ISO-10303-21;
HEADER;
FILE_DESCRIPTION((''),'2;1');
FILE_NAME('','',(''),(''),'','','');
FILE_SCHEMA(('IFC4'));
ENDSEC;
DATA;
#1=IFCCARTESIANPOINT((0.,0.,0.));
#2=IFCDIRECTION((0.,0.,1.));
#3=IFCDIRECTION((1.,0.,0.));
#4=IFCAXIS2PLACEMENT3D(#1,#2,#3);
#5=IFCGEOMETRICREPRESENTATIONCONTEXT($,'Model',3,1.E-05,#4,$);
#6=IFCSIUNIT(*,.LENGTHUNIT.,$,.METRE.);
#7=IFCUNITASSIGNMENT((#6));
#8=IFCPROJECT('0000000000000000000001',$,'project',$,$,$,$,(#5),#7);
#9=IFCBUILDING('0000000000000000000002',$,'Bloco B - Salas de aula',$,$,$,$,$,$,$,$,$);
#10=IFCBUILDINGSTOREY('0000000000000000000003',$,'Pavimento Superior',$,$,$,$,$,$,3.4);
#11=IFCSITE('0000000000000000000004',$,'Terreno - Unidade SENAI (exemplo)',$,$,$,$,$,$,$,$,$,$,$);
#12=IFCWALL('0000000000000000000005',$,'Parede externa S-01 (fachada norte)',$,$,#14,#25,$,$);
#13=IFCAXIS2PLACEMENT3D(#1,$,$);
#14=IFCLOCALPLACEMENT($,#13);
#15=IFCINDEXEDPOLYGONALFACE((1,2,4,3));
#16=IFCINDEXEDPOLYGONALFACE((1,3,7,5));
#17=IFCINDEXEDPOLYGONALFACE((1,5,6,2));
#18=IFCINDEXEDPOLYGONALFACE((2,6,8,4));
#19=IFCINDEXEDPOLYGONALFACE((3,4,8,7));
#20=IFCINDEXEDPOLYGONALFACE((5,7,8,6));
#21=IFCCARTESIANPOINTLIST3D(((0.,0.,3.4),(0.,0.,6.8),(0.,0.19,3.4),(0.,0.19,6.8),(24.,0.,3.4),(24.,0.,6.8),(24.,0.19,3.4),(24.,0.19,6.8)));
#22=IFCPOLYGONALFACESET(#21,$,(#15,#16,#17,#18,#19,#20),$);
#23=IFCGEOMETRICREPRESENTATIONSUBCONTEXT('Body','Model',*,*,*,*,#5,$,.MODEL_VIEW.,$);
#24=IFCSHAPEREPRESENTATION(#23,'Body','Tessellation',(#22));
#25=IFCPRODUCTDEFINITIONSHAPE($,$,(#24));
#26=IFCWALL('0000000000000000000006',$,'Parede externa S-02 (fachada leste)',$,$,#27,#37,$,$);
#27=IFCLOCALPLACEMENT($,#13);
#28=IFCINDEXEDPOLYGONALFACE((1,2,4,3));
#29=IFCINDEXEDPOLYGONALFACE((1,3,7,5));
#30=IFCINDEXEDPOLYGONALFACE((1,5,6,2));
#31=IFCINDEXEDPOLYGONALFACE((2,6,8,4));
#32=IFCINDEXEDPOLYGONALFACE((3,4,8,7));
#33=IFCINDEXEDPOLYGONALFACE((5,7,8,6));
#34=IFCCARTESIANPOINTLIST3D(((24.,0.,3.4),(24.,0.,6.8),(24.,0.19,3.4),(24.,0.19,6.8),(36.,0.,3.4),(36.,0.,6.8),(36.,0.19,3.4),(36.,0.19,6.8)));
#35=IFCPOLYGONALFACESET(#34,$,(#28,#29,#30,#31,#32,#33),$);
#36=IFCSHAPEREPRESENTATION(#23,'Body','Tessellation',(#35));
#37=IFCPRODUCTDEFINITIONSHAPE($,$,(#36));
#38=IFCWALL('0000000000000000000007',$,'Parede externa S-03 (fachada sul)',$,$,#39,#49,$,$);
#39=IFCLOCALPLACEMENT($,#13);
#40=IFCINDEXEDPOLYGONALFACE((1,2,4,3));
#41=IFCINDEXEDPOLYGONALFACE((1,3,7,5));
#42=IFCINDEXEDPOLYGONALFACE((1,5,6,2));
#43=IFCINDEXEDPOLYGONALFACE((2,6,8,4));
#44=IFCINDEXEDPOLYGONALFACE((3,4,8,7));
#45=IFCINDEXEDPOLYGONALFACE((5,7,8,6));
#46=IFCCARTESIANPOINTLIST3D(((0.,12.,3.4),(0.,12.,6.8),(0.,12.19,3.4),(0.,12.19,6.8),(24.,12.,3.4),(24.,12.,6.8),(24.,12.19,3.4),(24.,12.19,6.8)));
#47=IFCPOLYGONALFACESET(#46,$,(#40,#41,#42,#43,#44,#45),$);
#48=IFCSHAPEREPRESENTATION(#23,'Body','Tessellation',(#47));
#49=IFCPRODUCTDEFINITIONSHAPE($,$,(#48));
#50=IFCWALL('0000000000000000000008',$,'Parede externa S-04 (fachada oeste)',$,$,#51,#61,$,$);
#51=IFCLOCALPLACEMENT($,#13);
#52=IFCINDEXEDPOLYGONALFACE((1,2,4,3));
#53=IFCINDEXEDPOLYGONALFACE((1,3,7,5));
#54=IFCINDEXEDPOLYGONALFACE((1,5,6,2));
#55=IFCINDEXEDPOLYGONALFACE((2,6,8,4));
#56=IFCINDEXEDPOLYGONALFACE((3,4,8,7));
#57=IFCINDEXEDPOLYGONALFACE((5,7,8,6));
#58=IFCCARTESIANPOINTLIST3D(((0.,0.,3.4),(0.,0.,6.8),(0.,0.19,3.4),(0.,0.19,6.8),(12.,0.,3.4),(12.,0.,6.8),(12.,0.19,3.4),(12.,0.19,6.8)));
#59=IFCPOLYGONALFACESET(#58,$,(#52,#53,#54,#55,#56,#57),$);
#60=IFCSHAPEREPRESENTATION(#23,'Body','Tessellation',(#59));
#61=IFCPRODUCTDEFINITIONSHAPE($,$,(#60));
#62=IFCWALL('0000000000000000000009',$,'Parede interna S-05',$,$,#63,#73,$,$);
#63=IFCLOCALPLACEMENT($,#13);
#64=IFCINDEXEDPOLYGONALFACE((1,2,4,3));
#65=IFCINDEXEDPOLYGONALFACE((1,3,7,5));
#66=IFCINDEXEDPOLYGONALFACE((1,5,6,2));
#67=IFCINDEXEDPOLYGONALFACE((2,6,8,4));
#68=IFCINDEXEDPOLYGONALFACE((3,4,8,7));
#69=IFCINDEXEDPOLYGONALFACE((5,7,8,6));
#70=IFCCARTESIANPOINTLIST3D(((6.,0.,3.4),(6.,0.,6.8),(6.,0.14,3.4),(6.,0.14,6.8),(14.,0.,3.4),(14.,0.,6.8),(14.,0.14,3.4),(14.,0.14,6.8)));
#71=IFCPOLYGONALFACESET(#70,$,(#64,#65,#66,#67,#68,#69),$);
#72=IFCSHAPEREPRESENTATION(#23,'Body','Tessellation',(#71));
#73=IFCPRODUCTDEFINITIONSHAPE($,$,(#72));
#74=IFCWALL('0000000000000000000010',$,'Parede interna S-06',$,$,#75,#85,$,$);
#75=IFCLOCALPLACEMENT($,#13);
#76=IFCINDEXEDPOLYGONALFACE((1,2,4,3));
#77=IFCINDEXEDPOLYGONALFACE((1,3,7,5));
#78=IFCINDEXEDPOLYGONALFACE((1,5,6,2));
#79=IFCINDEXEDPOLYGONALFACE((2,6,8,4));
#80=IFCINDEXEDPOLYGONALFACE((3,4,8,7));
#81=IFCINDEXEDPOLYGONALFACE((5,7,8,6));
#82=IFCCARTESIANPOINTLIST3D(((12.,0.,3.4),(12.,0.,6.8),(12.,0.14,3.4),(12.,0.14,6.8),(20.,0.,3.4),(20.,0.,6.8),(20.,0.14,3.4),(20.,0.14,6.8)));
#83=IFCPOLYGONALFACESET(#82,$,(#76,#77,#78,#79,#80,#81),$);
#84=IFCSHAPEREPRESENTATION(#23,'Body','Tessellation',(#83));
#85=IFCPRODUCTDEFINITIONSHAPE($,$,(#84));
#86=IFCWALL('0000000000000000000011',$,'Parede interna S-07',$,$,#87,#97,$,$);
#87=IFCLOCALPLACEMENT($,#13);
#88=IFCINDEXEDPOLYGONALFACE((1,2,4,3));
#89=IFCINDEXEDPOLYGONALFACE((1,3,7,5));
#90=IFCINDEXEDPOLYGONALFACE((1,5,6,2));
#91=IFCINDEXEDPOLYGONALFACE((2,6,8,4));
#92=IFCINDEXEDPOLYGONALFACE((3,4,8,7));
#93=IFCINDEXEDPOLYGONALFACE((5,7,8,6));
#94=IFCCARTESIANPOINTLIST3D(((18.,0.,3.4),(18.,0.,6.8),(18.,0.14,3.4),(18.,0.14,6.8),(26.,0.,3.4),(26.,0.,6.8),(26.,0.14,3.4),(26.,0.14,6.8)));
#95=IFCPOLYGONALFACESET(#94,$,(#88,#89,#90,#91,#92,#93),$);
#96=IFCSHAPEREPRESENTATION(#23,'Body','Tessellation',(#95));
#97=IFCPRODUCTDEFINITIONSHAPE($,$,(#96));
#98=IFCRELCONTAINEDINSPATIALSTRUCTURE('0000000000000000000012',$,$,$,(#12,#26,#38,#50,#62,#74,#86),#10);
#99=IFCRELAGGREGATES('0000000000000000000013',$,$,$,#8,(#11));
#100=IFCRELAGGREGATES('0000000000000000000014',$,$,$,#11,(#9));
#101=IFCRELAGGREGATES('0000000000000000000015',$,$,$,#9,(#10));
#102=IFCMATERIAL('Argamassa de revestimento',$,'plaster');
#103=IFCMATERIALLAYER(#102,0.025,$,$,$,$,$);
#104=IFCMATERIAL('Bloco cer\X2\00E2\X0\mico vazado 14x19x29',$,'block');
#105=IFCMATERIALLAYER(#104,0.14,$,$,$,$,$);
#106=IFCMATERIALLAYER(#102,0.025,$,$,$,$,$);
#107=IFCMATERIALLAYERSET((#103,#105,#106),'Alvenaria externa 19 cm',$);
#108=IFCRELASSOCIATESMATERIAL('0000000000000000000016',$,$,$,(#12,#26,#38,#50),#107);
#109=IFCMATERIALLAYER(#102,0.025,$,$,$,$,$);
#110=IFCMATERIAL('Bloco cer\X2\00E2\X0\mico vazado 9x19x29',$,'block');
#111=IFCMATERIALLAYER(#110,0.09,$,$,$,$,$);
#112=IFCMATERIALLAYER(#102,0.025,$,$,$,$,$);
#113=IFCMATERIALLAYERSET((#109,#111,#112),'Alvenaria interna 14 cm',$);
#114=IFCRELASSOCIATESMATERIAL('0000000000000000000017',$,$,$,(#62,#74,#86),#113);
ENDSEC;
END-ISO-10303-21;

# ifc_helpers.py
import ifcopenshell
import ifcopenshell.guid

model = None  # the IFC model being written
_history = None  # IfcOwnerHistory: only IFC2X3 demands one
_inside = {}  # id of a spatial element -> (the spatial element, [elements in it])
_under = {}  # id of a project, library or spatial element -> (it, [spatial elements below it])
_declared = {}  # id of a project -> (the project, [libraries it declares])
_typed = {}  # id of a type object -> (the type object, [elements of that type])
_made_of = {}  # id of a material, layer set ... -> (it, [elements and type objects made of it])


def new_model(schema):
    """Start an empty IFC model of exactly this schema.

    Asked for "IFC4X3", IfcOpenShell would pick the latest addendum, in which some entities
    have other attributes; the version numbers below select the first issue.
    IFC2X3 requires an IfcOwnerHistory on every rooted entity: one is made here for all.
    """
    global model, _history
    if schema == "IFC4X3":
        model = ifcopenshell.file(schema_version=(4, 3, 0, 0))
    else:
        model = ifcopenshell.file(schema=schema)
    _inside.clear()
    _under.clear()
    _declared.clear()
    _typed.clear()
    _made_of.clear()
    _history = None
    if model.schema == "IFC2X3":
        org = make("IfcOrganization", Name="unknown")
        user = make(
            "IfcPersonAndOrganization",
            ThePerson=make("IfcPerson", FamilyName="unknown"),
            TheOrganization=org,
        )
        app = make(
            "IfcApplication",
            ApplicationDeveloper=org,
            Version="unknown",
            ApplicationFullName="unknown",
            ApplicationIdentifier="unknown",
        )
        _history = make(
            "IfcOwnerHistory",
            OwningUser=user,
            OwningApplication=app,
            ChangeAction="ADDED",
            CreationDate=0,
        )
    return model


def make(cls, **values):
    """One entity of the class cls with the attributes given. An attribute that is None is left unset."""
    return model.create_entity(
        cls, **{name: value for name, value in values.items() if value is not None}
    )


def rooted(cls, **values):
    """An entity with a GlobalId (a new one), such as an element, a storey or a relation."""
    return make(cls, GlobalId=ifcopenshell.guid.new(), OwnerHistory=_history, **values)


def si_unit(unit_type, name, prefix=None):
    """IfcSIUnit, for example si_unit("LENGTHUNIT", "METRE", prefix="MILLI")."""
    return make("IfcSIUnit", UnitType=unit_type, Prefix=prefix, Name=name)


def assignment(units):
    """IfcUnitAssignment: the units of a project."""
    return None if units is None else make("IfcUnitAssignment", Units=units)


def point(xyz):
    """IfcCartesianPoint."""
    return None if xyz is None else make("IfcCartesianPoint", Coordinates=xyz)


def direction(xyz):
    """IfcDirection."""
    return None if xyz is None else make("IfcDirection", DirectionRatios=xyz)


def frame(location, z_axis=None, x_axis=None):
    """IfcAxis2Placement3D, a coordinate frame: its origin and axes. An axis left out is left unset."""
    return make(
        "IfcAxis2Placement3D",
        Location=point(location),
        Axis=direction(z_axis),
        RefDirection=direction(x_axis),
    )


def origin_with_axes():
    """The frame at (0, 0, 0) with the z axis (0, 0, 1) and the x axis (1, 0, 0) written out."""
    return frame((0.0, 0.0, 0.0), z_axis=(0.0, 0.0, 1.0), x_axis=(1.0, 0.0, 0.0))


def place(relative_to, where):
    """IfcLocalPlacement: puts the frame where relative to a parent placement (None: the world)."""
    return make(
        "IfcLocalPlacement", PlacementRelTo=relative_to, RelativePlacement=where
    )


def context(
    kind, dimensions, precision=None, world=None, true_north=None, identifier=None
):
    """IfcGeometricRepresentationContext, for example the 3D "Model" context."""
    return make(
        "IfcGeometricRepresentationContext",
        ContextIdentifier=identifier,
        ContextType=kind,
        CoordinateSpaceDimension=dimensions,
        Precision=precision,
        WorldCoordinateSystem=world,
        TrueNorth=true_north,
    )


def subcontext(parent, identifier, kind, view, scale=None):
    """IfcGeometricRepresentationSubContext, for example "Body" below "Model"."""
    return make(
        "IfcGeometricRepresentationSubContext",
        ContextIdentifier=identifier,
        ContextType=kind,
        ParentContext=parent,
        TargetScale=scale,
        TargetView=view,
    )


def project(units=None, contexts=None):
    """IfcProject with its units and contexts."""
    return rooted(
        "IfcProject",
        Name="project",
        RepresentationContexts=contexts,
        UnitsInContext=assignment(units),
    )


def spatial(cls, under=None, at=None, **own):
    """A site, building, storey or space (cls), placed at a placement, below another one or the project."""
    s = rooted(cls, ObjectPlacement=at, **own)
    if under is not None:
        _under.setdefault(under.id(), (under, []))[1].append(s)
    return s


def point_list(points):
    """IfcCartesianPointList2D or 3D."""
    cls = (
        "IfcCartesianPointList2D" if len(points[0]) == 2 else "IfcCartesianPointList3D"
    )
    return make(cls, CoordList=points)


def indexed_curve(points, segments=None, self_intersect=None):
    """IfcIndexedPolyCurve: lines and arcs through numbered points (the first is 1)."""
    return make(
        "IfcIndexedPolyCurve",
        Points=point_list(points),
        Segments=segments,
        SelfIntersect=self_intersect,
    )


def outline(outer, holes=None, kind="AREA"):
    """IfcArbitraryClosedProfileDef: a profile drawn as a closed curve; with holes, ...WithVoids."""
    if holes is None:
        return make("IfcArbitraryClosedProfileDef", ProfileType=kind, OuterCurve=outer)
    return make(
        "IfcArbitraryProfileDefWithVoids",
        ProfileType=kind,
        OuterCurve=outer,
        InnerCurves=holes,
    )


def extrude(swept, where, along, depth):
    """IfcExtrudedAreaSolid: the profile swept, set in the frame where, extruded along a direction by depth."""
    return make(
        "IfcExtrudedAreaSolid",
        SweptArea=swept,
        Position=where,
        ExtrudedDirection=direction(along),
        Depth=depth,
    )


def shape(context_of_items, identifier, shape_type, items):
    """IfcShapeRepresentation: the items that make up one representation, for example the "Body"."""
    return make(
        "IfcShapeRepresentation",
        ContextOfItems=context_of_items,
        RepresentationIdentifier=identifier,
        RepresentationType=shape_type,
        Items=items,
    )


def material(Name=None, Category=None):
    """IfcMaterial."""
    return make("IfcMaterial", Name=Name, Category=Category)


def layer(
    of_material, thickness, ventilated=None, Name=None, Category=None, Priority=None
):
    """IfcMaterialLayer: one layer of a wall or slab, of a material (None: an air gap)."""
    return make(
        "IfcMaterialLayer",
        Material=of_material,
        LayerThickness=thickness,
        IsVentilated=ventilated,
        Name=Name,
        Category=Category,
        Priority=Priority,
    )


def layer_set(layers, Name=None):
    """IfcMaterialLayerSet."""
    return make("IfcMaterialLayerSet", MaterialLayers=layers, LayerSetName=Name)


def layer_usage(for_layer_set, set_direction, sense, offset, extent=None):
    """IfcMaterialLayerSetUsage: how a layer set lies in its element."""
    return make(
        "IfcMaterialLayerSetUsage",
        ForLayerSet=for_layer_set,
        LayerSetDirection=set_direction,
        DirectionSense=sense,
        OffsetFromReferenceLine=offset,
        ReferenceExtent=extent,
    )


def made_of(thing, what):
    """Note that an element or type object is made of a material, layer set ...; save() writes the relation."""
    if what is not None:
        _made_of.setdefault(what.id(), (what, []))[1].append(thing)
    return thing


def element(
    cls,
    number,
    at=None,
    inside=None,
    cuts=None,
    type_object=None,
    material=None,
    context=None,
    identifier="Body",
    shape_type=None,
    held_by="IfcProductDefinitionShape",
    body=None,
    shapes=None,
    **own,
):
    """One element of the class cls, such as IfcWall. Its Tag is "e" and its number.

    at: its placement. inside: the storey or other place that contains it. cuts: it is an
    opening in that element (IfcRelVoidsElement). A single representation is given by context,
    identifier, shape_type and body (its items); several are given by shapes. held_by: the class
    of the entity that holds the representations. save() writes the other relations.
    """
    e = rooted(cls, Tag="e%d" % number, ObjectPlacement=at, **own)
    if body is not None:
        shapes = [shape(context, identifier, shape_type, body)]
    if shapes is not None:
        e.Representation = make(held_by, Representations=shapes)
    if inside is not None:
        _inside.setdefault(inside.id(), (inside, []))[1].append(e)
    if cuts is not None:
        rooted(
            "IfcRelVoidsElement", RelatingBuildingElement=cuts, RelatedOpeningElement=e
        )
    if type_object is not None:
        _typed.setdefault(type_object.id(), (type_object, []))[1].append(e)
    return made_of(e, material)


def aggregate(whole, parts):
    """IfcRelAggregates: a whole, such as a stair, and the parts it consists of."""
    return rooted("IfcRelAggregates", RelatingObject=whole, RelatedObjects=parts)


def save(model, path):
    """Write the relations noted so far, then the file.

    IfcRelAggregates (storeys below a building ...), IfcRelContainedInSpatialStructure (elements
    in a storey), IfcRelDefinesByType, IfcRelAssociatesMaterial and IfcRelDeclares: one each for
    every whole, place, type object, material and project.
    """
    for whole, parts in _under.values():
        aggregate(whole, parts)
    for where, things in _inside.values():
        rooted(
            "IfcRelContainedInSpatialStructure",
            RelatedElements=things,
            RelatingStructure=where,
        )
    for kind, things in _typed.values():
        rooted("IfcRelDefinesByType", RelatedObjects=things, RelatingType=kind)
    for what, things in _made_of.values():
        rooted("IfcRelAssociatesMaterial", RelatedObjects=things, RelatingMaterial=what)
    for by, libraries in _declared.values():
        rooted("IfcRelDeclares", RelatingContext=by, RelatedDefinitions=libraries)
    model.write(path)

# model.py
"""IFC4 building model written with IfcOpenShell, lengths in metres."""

from ifc_helpers import new_model, si_unit, frame, origin_with_axes, place, context, subcontext, project, spatial, indexed_curve, outline, extrude, material, layer, layer_set, layer_usage, element, save


model = new_model("IFC4")

# Units and contexts
model_context = context("Model", 3, precision=1e-05, world=origin_with_axes())
body_context = subcontext(model_context, "Body", "Model", "MODEL_VIEW")
ifc_project = project(units=[si_unit("LENGTHUNIT", "METRE")], contexts=[model_context])

# Site, building, storey
site = spatial("IfcSite", under=ifc_project, Name="Terreno - Unidade SENAI (exemplo)")
building = spatial("IfcBuilding", under=site, Name="Bloco B - Salas de aula")
storey = spatial("IfcBuildingStorey", under=building, Name="Pavimento Superior", Elevation=3.4)

# Walls
ifc_material_1 = material(Name="Argamassa de revestimento", Category="plaster")
ifc_layer_1 = layer(ifc_material_1, 0.025)
ifc_material_2 = material(Name="Bloco cerâmico vazado 14x19x29", Category="block")
ifc_layer_2 = layer(ifc_material_2, 0.14)
ifc_layer_3 = layer(ifc_material_1, 0.025)
ifc_layer_set_1 = layer_set([ifc_layer_1, ifc_layer_2, ifc_layer_3], Name="Alvenaria externa 19 cm")
ifc_layer_usage_1 = layer_usage(ifc_layer_set_1, "AXIS2", "POSITIVE", 0.0)
wall_1_placement = place(None, frame((0.0, 0.0, 3.4), z_axis=(0.0, 0.0, 1.0), x_axis=(1.0, 0.0, 0.0)))
element("IfcWall", 1, at=wall_1_placement, inside=storey, material=ifc_layer_usage_1, Name="Parede externa S-01 (fachada norte)", context=body_context, shape_type="SweptSolid", body=[
    extrude(outline(indexed_curve([(0.0, 0.0), (0.0, 0.19), (24.0, 0.19), (24.0, 0.0), (0.0, 0.0)], self_intersect=False)), origin_with_axes(), (0.0, 0.0, 1.0), 3.4),
])
ifc_layer_usage_2 = layer_usage(ifc_layer_set_1, "AXIS2", "POSITIVE", 0.0)
wall_2_placement = place(None, frame((24.0, 0.0, 3.4), z_axis=(0.0, 0.0, 1.0), x_axis=(1.0, 0.0, 0.0)))
element("IfcWall", 2, at=wall_2_placement, inside=storey, material=ifc_layer_usage_2, Name="Parede externa S-02 (fachada leste)", context=body_context, shape_type="SweptSolid", body=[
    extrude(outline(indexed_curve([(0.0, 0.0), (0.0, 0.19), (12.0, 0.19), (12.0, 0.0), (0.0, 0.0)], self_intersect=False)), origin_with_axes(), (0.0, 0.0, 1.0), 3.4),
])
ifc_layer_usage_3 = layer_usage(ifc_layer_set_1, "AXIS2", "POSITIVE", 0.0)
wall_3_placement = place(None, frame((0.0, 12.0, 3.4), z_axis=(0.0, 0.0, 1.0), x_axis=(1.0, 0.0, 0.0)))
element("IfcWall", 3, at=wall_3_placement, inside=storey, material=ifc_layer_usage_3, Name="Parede externa S-03 (fachada sul)", context=body_context, shape_type="SweptSolid", body=[
    extrude(outline(indexed_curve([(0.0, 0.0), (0.0, 0.19), (24.0, 0.19), (24.0, 0.0), (0.0, 0.0)], self_intersect=False)), origin_with_axes(), (0.0, 0.0, 1.0), 3.4),
])
ifc_layer_usage_4 = layer_usage(ifc_layer_set_1, "AXIS2", "POSITIVE", 0.0)
wall_4_placement = place(None, frame((0.0, 0.0, 3.4), z_axis=(0.0, 0.0, 1.0), x_axis=(1.0, 0.0, 0.0)))
element("IfcWall", 4, at=wall_4_placement, inside=storey, material=ifc_layer_usage_4, Name="Parede externa S-04 (fachada oeste)", context=body_context, shape_type="SweptSolid", body=[
    extrude(outline(indexed_curve([(0.0, 0.0), (0.0, 0.19), (12.0, 0.19), (12.0, 0.0), (0.0, 0.0)], self_intersect=False)), origin_with_axes(), (0.0, 0.0, 1.0), 3.4),
])
ifc_layer_4 = layer(ifc_material_1, 0.025)
ifc_material_3 = material(Name="Bloco cerâmico vazado 9x19x29", Category="block")
ifc_layer_5 = layer(ifc_material_3, 0.09)
ifc_layer_6 = layer(ifc_material_1, 0.025)
ifc_layer_set_2 = layer_set([ifc_layer_4, ifc_layer_5, ifc_layer_6], Name="Alvenaria interna 14 cm")
ifc_layer_usage_5 = layer_usage(ifc_layer_set_2, "AXIS2", "POSITIVE", 0.0)
wall_5_placement = place(None, frame((6.0, 0.0, 3.4), z_axis=(0.0, 0.0, 1.0), x_axis=(1.0, 0.0, 0.0)))
element("IfcWall", 5, at=wall_5_placement, inside=storey, material=ifc_layer_usage_5, Name="Parede interna S-05", context=body_context, shape_type="SweptSolid", body=[
    extrude(outline(indexed_curve([(0.0, 0.0), (0.0, 0.14), (8.0, 0.14), (8.0, 0.0), (0.0, 0.0)], self_intersect=False)), origin_with_axes(), (0.0, 0.0, 1.0), 3.4),
])
ifc_layer_usage_6 = layer_usage(ifc_layer_set_2, "AXIS2", "POSITIVE", 0.0)
wall_6_placement = place(None, frame((12.0, 0.0, 3.4), z_axis=(0.0, 0.0, 1.0), x_axis=(1.0, 0.0, 0.0)))
element("IfcWall", 6, at=wall_6_placement, inside=storey, material=ifc_layer_usage_6, Name="Parede interna S-06", context=body_context, shape_type="SweptSolid", body=[
    extrude(outline(indexed_curve([(0.0, 0.0), (0.0, 0.14), (8.0, 0.14), (8.0, 0.0), (0.0, 0.0)], self_intersect=False)), origin_with_axes(), (0.0, 0.0, 1.0), 3.4),
])
ifc_layer_usage_7 = layer_usage(ifc_layer_set_2, "AXIS2", "POSITIVE", 0.0)
wall_7_placement = place(None, frame((18.0, 0.0, 3.4), z_axis=(0.0, 0.0, 1.0), x_axis=(1.0, 0.0, 0.0)))
element("IfcWall", 7, at=wall_7_placement, inside=storey, material=ifc_layer_usage_7, Name="Parede interna S-07", context=body_context, shape_type="SweptSolid", body=[
    extrude(outline(indexed_curve([(0.0, 0.0), (0.0, 0.14), (8.0, 0.14), (8.0, 0.0), (0.0, 0.0)], self_intersect=False)), origin_with_axes(), (0.0, 0.0, 1.0), 3.4),
])

save(model, "model.ifc")
